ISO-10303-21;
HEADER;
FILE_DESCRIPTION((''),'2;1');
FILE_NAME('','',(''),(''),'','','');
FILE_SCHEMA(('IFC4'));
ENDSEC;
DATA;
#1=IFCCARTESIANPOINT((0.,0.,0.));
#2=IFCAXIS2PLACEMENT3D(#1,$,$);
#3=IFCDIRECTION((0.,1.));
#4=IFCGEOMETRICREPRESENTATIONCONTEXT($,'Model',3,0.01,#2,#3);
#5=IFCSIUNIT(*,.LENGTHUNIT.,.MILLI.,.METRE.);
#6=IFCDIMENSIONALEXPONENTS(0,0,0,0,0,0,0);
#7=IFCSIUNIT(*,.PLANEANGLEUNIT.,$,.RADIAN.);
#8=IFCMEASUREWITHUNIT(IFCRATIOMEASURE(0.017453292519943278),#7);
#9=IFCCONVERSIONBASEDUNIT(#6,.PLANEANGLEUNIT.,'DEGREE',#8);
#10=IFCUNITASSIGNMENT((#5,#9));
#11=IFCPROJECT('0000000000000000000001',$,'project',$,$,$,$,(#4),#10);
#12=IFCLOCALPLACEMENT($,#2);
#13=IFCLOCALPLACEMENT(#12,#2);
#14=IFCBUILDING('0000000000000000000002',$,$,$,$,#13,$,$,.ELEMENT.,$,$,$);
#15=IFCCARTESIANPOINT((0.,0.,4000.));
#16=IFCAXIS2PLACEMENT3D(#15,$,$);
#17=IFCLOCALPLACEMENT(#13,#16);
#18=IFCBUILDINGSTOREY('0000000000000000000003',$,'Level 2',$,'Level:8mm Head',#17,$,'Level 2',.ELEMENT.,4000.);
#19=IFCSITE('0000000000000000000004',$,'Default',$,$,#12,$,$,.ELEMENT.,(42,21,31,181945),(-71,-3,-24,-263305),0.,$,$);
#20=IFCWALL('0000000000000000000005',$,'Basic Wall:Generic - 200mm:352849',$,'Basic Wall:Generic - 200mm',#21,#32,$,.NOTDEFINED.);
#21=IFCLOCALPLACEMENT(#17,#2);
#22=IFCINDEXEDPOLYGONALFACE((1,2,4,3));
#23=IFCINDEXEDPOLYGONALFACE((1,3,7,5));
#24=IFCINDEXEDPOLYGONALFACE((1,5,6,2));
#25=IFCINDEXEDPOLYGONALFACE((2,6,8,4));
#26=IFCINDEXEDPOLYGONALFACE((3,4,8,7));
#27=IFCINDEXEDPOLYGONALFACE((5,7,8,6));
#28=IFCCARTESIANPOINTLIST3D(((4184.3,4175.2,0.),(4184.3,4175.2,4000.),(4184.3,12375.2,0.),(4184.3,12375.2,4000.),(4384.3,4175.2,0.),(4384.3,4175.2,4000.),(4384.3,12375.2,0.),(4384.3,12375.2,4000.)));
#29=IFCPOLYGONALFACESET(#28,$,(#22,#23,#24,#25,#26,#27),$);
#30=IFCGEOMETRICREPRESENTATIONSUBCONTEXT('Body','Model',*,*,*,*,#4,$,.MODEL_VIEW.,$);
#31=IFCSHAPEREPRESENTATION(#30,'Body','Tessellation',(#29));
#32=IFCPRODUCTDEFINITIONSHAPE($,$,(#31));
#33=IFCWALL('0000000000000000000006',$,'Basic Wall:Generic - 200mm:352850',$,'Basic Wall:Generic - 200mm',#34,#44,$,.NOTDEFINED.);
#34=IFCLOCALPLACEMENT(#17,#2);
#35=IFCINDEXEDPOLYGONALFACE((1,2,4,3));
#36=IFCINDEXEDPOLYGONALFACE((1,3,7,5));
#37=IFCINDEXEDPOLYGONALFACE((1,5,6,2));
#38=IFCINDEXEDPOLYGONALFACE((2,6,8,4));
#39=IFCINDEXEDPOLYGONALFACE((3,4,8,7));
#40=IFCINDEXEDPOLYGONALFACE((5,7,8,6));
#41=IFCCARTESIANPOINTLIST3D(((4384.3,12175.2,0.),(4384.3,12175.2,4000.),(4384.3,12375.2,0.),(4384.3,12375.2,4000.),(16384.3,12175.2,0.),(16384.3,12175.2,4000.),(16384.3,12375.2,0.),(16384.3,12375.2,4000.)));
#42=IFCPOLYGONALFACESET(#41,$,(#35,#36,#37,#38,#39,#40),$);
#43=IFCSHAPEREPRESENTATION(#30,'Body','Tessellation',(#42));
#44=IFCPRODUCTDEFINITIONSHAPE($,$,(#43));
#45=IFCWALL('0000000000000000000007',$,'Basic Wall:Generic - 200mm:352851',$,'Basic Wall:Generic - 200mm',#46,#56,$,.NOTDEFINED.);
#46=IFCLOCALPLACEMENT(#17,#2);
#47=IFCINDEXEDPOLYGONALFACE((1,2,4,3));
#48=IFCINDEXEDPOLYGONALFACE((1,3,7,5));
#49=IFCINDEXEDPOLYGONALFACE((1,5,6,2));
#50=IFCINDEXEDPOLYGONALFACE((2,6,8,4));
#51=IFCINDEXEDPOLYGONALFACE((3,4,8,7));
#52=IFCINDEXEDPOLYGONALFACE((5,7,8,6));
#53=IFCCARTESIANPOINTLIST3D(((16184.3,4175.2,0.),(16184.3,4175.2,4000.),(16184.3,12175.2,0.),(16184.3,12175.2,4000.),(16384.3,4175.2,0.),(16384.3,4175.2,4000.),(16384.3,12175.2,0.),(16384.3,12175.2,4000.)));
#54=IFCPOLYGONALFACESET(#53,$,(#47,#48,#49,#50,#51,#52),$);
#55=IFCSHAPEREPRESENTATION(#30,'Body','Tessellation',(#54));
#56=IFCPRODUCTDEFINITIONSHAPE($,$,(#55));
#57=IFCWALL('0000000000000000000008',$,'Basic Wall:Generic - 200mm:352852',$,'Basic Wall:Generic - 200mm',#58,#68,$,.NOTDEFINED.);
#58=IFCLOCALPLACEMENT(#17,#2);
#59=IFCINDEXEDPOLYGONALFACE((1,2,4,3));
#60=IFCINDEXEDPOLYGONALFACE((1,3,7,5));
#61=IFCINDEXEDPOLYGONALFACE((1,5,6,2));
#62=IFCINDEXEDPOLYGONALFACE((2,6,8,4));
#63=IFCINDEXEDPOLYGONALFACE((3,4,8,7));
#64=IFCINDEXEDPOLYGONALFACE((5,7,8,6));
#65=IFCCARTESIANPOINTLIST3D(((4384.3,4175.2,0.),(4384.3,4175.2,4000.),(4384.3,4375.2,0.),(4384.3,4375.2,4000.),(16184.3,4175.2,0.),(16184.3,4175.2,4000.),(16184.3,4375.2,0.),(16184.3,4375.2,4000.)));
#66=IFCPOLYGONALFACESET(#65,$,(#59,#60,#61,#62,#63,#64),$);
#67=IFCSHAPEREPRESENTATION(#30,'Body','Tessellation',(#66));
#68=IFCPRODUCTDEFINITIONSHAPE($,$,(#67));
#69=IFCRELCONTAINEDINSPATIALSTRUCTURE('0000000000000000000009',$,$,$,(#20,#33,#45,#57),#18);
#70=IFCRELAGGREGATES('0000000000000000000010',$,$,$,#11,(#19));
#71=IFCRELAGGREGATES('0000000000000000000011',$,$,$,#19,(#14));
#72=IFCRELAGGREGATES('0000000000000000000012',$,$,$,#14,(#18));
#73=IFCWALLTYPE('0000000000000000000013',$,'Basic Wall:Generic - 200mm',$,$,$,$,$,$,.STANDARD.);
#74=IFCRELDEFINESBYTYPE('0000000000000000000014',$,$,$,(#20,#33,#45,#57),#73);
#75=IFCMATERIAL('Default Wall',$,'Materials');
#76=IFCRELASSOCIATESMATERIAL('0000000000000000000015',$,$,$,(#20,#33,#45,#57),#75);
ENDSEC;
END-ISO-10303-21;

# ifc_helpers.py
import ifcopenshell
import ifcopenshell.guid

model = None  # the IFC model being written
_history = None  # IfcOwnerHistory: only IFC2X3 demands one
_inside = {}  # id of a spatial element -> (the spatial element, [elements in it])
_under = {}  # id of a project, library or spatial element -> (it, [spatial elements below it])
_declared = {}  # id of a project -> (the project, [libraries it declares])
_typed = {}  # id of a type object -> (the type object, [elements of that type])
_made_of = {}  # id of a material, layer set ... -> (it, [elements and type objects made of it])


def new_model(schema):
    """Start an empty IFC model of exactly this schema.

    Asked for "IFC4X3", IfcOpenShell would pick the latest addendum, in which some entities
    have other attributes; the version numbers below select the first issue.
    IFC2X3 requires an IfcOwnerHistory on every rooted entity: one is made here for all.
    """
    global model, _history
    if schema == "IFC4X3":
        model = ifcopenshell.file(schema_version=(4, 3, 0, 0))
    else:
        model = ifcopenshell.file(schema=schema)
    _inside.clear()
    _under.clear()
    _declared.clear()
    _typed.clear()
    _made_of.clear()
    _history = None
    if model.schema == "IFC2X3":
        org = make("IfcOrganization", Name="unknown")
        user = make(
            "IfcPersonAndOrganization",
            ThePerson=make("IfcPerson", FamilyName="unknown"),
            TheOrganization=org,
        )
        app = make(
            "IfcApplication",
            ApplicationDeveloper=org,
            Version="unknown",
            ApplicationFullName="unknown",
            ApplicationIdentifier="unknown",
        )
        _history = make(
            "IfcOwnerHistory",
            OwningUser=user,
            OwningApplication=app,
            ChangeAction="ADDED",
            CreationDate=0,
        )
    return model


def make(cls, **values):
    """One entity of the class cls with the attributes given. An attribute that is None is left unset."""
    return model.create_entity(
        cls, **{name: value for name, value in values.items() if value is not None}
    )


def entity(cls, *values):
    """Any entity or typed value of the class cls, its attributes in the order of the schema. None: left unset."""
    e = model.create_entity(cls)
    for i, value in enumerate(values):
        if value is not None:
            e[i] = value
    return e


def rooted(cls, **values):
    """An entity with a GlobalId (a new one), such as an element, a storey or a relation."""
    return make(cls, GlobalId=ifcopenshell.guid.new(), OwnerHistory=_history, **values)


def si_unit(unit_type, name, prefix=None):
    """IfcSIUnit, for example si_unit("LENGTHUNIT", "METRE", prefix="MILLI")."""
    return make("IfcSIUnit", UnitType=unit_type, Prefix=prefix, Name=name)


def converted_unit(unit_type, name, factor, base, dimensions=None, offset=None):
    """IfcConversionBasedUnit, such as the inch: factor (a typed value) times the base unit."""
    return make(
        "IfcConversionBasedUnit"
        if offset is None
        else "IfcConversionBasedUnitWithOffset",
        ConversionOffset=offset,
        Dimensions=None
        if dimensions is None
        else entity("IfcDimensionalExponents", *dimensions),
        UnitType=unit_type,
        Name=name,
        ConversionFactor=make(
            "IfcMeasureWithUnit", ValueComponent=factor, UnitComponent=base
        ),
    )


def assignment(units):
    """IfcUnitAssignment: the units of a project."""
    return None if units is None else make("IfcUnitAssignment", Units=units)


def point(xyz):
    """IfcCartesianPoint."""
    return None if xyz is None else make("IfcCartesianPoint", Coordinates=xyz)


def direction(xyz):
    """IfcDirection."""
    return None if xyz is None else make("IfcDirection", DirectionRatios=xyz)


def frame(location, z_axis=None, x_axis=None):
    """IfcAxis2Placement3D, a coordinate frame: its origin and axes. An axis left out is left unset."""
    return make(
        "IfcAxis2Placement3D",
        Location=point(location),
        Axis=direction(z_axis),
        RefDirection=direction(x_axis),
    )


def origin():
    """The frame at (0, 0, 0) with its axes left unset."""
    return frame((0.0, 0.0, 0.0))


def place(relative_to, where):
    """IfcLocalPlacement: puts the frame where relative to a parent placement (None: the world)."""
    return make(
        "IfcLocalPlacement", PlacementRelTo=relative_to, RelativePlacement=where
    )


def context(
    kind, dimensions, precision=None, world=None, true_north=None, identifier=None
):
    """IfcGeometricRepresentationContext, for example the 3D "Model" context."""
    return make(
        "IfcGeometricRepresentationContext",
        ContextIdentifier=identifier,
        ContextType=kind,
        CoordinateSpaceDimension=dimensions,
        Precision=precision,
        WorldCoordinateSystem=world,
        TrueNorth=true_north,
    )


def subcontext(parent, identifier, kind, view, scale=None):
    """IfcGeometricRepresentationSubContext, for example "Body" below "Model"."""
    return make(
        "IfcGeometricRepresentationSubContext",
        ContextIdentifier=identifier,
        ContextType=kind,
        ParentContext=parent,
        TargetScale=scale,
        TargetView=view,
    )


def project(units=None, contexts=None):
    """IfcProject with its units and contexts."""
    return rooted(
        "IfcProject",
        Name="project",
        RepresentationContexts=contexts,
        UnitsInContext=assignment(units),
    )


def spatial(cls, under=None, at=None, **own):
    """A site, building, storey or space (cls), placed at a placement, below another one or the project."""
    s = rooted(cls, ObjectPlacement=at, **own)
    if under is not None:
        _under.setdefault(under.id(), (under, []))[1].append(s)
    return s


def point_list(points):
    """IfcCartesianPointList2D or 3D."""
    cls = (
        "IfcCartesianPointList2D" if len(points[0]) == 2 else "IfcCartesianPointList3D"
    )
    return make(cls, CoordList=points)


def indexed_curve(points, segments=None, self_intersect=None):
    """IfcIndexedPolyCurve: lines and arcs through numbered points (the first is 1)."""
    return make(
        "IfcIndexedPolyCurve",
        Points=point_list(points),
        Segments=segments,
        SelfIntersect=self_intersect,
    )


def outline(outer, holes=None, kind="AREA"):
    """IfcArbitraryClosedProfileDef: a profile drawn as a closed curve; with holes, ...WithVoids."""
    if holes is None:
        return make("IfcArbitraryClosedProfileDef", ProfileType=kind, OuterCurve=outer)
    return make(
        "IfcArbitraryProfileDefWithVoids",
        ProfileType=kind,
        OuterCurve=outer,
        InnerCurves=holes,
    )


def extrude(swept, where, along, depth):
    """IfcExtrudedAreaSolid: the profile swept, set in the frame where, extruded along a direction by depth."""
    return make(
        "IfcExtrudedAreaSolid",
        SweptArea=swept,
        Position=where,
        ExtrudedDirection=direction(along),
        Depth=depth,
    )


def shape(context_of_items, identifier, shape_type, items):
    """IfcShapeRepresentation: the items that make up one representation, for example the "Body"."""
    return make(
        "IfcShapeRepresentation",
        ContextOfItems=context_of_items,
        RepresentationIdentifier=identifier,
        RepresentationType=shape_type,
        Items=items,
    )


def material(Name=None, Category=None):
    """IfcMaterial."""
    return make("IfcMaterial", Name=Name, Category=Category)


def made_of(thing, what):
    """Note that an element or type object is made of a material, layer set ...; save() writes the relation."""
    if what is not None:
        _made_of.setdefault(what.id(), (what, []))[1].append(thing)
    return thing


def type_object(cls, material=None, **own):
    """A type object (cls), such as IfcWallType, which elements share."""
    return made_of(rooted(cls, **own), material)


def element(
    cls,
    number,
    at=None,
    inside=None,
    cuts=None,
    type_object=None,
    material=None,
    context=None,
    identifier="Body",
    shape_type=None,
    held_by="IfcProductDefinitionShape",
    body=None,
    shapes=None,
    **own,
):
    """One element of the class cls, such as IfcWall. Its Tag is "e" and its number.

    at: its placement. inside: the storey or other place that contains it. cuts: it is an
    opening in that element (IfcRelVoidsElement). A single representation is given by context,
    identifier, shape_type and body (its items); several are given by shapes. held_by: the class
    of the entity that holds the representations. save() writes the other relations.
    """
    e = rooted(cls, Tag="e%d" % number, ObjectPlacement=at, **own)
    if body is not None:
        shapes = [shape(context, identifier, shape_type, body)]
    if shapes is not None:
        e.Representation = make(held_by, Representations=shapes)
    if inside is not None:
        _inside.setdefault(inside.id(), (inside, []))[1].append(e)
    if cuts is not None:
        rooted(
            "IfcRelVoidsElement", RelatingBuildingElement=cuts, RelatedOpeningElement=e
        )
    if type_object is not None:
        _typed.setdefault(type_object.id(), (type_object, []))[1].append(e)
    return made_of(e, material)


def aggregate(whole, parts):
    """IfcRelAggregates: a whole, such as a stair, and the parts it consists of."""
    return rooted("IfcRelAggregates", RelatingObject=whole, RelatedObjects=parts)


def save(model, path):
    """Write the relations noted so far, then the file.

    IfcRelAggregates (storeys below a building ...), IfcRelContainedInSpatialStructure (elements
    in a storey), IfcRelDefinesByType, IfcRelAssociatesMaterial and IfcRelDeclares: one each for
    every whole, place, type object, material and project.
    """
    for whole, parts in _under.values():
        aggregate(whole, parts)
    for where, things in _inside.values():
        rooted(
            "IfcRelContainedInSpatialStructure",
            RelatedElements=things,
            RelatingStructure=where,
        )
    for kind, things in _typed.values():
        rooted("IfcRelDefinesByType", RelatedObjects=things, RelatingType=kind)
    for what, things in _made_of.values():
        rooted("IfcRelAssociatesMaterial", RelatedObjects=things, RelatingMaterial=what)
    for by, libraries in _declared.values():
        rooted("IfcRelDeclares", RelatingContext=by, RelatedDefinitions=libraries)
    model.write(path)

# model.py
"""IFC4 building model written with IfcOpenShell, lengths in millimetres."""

from ifc_helpers import new_model, entity, si_unit, converted_unit, direction, frame, origin, place, context, subcontext, project, spatial, indexed_curve, outline, extrude, material, type_object, element, save


model = new_model("IFC4")

# Units and contexts
model_context = context("Model", 3, precision=0.01, world=origin(), true_north=direction((0.0, 1.0)))
body_context = subcontext(model_context, "Body", "Model", "MODEL_VIEW")
ifc_project = project(units=[si_unit("LENGTHUNIT", "METRE", prefix="MILLI"), converted_unit("PLANEANGLEUNIT", "DEGREE", entity("IfcRatioMeasure", 0.017453292519943278), si_unit("PLANEANGLEUNIT", "RADIAN"), dimensions=[0, 0, 0, 0, 0, 0, 0])], contexts=[model_context])

# Site, building, storey
site_placement = place(None, origin())
site = spatial("IfcSite", under=ifc_project, at=site_placement, Name="Default", CompositionType="ELEMENT", RefLatitude=(42, 21, 31, 181945), RefLongitude=(-71, -3, -24, -263305), RefElevation=0.0)
building_placement = place(site_placement, origin())
building = spatial("IfcBuilding", under=site, at=building_placement, CompositionType="ELEMENT")
storey_placement = place(building_placement, frame((0.0, 0.0, 4000.0)))
storey = spatial("IfcBuildingStorey", under=building, at=storey_placement, Name="Level 2", ObjectType="Level:8mm Head", LongName="Level 2", CompositionType="ELEMENT", Elevation=4000.0)

# Walls
ifc_material_1 = material(Name="Default Wall", Category="Materials")
wall_type = type_object("IfcWallType", Name="Basic Wall:Generic - 200mm", PredefinedType="STANDARD")
wall_1_placement = place(storey_placement, frame((4284.3, 4175.2, 0.0), z_axis=(0.0, 0.0, 1.0), x_axis=(0.0, 1.0, 0.0)))
element("IfcWall", 1, at=wall_1_placement, inside=storey, type_object=wall_type, material=ifc_material_1, Name="Basic Wall:Generic - 200mm:352849", ObjectType="Basic Wall:Generic - 200mm", PredefinedType="NOTDEFINED", context=body_context, shape_type="SweptSolid", body=[
    extrude(outline(indexed_curve([(8200.0, 100.0), (0.0, 100.0), (0.0, -100.0), (8200.0, -100.0), (8200.0, 100.0)], self_intersect=False)), origin(), (0.0, 0.0, 1.0), 4000.0),
])
wall_2_placement = place(storey_placement, frame((4384.3, 12275.2, 0.0)))
element("IfcWall", 2, at=wall_2_placement, inside=storey, type_object=wall_type, material=ifc_material_1, Name="Basic Wall:Generic - 200mm:352850", ObjectType="Basic Wall:Generic - 200mm", PredefinedType="NOTDEFINED", context=body_context, shape_type="SweptSolid", body=[
    extrude(outline(indexed_curve([(12000.0, 100.0), (0.0, 100.0), (0.0, -100.0), (12000.0, -100.0), (12000.0, 100.0)], self_intersect=False)), origin(), (0.0, 0.0, 1.0), 4000.0),
])
wall_3_placement = place(storey_placement, frame((16284.3, 12175.2, 0.0), z_axis=(0.0, 0.0, 1.0), x_axis=(0.0, -1.0, 0.0)))
element("IfcWall", 3, at=wall_3_placement, inside=storey, type_object=wall_type, material=ifc_material_1, Name="Basic Wall:Generic - 200mm:352851", ObjectType="Basic Wall:Generic - 200mm", PredefinedType="NOTDEFINED", context=body_context, shape_type="SweptSolid", body=[
    extrude(outline(indexed_curve([(8000.0, 100.0), (0.0, 100.0), (0.0, -100.0), (8000.0, -100.0), (8000.0, 100.0)], self_intersect=False)), origin(), (0.0, 0.0, 1.0), 4000.0),
])
wall_4_placement = place(storey_placement, frame((16184.3, 4275.2, 0.0), z_axis=(0.0, 0.0, 1.0), x_axis=(-1.0, 0.0, 0.0)))
element("IfcWall", 4, at=wall_4_placement, inside=storey, type_object=wall_type, material=ifc_material_1, Name="Basic Wall:Generic - 200mm:352852", ObjectType="Basic Wall:Generic - 200mm", PredefinedType="NOTDEFINED", context=body_context, shape_type="SweptSolid", body=[
    extrude(outline(indexed_curve([(11800.0, 100.0), (0.0, 100.0), (0.0, -100.0), (11800.0, -100.0), (11800.0, 100.0)], self_intersect=False)), origin(), (0.0, 0.0, 1.0), 4000.0),
])

save(model, "model.ifc")
